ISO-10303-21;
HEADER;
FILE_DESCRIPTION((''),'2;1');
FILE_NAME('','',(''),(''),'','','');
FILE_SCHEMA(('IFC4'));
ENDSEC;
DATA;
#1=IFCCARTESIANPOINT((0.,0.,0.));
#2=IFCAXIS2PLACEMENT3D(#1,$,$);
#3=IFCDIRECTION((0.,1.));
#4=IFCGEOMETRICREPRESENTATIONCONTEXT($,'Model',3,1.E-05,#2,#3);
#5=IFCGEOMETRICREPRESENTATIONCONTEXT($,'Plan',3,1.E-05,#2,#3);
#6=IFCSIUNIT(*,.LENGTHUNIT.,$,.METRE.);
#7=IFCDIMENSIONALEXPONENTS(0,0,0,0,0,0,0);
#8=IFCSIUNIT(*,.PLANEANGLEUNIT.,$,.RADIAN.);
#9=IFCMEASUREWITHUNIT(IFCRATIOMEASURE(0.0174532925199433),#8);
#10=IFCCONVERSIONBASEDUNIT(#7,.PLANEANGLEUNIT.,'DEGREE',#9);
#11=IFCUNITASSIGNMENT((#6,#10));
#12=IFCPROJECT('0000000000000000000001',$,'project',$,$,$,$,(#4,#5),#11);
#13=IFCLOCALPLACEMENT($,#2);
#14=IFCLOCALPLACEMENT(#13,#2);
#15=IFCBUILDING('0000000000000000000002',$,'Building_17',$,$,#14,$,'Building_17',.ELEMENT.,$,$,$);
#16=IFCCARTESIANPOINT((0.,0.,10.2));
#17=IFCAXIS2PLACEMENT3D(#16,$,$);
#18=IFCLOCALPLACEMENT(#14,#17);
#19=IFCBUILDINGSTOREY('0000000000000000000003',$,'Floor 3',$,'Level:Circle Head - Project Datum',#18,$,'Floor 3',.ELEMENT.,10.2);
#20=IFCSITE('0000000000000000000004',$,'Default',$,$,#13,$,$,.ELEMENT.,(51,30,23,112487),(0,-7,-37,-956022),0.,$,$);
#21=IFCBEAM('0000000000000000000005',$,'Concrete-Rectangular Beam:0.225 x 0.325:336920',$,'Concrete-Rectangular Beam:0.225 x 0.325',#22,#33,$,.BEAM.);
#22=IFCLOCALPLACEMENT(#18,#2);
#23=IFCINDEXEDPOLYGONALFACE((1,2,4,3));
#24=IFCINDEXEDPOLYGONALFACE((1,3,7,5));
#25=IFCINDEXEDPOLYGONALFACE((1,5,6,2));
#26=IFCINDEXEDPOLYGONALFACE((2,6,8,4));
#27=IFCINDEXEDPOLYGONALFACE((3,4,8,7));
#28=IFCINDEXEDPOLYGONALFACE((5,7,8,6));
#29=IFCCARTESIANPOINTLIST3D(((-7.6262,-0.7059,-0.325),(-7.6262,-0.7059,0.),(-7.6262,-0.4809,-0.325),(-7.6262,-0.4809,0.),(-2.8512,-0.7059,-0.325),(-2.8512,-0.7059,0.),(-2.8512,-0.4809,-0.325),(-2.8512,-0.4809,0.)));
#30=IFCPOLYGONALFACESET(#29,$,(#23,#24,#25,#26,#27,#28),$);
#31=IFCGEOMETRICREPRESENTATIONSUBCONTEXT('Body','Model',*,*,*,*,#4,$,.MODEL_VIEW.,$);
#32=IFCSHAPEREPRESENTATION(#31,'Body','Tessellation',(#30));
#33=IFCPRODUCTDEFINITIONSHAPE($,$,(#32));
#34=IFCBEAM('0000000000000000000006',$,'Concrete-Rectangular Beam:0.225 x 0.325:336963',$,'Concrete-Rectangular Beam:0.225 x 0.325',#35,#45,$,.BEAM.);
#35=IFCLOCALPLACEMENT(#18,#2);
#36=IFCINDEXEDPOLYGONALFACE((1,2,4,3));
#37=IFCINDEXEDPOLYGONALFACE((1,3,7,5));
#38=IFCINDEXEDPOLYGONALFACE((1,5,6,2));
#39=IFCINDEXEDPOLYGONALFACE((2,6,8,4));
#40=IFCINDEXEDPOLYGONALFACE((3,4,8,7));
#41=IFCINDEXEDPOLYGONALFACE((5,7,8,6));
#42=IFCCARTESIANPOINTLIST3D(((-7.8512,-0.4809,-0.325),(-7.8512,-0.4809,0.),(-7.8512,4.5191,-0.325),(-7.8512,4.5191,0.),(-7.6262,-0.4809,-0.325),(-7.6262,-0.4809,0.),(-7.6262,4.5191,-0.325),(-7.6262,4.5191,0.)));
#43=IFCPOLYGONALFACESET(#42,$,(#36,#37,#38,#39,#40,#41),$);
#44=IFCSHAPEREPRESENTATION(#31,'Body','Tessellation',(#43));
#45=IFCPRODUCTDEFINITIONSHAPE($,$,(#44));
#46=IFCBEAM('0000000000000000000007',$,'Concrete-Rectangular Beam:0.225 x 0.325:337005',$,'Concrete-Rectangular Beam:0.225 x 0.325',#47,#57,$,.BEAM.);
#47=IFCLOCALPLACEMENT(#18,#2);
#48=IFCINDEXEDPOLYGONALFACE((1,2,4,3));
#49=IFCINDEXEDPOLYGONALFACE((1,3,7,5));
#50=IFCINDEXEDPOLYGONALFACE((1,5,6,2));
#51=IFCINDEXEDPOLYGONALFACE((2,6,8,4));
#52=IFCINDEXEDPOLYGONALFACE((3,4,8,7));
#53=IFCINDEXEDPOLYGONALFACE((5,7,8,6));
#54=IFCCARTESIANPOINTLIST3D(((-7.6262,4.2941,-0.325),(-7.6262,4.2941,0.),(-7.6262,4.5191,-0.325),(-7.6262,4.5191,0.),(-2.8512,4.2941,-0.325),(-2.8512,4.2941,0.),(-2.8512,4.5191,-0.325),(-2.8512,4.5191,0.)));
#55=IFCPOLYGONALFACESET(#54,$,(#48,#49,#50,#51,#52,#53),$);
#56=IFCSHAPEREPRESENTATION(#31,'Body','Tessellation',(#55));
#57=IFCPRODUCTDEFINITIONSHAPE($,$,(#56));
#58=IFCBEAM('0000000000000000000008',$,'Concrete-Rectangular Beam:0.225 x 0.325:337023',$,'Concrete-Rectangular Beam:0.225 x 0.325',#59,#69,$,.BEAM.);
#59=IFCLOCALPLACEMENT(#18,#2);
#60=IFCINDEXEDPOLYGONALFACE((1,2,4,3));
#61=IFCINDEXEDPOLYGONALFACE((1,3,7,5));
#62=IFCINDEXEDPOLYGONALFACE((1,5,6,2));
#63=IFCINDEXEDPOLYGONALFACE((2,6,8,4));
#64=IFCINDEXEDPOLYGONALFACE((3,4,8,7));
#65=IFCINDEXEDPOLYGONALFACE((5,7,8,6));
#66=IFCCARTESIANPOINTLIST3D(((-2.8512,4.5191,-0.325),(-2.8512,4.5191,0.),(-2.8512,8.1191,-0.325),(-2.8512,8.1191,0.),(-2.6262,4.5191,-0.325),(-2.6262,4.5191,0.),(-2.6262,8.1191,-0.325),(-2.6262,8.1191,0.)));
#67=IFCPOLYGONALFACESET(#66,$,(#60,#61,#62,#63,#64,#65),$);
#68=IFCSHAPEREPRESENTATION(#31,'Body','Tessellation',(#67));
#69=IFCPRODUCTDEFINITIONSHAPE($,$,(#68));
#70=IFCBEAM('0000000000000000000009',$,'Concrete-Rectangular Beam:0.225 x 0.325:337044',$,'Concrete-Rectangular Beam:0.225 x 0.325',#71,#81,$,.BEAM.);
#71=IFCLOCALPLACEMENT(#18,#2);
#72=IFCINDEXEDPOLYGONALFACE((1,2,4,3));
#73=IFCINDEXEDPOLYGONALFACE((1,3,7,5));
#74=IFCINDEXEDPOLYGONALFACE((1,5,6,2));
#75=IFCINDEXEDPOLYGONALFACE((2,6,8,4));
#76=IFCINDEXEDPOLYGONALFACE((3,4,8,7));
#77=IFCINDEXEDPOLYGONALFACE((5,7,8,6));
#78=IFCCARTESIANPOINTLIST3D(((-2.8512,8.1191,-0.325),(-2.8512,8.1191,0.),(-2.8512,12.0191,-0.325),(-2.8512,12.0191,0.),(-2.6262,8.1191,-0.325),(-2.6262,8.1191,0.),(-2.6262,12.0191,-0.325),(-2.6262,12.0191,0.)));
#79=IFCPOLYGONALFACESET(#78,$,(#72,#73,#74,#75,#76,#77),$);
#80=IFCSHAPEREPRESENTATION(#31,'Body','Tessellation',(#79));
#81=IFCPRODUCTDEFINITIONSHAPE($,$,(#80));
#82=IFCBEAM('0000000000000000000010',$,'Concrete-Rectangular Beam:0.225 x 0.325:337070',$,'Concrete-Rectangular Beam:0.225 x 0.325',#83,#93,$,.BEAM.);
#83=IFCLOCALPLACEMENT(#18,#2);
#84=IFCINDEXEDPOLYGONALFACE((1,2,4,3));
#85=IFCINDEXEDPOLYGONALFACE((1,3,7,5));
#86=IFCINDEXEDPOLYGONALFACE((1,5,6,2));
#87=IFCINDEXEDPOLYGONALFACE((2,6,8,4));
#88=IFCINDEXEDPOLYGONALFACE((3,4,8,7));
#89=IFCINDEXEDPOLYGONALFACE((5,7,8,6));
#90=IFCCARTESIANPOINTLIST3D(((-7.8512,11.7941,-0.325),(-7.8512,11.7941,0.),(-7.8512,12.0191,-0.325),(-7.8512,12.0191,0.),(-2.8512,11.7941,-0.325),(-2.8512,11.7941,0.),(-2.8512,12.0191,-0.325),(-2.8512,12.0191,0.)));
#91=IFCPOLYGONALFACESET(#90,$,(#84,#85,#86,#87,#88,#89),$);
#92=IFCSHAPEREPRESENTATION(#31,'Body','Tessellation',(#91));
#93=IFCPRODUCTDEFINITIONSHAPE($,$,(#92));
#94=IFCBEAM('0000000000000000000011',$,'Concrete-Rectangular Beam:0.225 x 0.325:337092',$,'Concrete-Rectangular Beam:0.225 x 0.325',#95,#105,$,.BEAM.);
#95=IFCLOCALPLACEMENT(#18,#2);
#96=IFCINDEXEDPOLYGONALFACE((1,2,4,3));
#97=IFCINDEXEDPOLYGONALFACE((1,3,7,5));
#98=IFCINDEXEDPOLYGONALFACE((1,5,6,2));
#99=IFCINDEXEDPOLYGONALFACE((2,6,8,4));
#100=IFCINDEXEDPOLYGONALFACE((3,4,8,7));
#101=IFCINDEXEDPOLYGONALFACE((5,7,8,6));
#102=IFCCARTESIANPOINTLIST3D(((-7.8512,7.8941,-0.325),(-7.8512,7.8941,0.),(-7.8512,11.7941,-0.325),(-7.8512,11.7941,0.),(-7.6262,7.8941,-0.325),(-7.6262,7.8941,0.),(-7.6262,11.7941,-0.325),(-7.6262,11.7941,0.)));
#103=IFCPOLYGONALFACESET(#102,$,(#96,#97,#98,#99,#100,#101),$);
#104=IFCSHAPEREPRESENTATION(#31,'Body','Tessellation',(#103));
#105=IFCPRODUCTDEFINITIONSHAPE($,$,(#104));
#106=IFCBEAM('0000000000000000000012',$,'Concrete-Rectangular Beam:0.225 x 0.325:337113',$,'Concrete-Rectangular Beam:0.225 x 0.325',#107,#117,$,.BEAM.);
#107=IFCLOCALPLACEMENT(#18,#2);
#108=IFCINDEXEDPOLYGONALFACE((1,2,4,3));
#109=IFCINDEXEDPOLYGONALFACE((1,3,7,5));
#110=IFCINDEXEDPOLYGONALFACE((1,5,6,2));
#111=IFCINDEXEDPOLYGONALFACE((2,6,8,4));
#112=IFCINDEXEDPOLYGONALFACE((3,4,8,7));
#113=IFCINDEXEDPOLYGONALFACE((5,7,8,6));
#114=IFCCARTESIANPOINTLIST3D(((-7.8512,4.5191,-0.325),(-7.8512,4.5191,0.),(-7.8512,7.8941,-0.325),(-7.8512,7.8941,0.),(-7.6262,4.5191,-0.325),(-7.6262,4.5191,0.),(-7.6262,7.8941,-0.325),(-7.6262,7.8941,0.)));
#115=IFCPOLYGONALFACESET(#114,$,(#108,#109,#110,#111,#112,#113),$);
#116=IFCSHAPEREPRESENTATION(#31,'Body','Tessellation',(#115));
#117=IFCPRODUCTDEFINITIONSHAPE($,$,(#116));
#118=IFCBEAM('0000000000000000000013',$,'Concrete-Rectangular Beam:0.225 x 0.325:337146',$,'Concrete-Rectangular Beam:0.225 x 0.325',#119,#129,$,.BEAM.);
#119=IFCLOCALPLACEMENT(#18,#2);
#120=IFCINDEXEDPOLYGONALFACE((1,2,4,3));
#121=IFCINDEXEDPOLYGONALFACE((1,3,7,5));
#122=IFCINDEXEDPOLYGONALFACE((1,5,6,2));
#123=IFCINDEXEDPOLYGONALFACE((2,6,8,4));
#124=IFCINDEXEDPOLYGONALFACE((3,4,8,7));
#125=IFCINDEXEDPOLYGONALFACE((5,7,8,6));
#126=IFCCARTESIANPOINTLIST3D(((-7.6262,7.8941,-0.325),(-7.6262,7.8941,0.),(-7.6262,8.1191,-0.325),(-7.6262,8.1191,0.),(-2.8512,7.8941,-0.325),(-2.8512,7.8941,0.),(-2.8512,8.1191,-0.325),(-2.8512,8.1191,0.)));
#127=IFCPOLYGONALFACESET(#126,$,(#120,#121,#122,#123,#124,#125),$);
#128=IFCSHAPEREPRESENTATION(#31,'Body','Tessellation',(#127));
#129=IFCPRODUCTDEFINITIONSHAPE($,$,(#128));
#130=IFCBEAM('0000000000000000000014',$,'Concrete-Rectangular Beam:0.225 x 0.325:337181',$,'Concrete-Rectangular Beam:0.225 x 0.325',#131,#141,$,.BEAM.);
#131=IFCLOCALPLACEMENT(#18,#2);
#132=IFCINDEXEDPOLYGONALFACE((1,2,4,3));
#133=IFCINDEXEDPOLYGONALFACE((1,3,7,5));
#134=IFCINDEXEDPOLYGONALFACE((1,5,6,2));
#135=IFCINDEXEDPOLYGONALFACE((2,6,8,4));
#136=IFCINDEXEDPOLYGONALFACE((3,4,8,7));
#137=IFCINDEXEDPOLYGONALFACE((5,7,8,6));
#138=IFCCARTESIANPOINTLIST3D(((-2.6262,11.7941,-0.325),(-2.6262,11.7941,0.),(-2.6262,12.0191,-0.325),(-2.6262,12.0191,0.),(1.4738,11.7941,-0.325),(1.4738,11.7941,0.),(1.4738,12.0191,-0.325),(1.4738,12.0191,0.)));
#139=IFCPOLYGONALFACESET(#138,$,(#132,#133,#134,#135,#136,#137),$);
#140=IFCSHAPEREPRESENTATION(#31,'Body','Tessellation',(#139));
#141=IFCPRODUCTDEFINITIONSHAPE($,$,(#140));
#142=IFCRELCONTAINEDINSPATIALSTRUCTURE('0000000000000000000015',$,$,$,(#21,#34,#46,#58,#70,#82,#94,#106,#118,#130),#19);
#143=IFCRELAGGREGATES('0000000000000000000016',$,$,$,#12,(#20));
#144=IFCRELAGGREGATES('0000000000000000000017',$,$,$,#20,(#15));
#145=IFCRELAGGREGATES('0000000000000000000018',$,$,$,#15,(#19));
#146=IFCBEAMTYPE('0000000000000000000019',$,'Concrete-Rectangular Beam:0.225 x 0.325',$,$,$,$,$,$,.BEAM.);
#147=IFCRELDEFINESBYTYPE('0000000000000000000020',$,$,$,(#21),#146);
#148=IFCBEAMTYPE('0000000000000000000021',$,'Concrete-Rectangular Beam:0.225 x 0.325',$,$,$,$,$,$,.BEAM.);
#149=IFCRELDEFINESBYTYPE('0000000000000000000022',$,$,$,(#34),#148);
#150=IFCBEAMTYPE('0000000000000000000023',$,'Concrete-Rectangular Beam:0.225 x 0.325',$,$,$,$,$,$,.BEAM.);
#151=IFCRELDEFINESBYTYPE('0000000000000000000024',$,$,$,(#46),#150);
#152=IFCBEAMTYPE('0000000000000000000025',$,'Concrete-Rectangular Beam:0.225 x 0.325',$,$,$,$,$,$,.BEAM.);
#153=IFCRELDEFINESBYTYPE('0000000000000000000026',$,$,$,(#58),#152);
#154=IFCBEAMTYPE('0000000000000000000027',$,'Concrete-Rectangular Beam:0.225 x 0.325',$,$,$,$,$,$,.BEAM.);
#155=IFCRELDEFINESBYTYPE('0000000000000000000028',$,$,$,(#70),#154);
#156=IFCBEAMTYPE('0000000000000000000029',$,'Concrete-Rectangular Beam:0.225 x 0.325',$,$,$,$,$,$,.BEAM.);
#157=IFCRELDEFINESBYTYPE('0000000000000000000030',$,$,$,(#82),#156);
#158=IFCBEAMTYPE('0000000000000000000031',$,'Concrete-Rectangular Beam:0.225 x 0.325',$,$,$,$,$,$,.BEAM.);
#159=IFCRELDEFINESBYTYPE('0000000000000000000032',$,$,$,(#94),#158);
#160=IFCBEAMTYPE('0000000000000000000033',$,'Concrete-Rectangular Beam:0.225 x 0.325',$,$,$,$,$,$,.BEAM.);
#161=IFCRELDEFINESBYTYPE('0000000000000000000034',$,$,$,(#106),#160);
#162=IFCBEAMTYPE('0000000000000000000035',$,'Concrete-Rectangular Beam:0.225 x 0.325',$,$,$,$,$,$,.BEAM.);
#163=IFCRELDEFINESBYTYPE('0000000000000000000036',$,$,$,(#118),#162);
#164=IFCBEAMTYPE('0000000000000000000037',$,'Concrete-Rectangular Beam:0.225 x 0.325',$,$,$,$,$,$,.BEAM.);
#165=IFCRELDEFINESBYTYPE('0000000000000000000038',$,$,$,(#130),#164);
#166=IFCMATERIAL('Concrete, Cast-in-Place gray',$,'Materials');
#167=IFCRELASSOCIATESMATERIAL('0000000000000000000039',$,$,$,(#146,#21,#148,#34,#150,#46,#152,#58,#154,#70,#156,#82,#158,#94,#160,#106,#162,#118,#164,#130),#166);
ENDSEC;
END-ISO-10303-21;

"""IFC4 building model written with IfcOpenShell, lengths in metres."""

from ifc_helpers import new_model, entity, si_unit, converted_unit, direction, frame, origin, place, context, subcontext, project, spatial, indexed_curve, outline, extrude, source, transform, mapped, material, type_object, type_shapes, element, save


model = new_model("IFC4")

# Units and contexts
model_context = context("Model", 3, precision=1e-05, world=origin(), true_north=direction((0.0, 1.0)))
plan_context = context("Plan", 3, precision=1e-05, world=origin(), true_north=direction((0.0, 1.0)))
body_context = subcontext(model_context, "Body", "Model", "MODEL_VIEW")
ifc_project = project(units=[si_unit("LENGTHUNIT", "METRE"), converted_unit("PLANEANGLEUNIT", "DEGREE", entity("IfcRatioMeasure", 0.0174532925199433), si_unit("PLANEANGLEUNIT", "RADIAN"), dimensions=[0, 0, 0, 0, 0, 0, 0])], contexts=[model_context, plan_context])

# Site, building, storey
site_placement = place(None, origin())
site = spatial("IfcSite", under=ifc_project, at=site_placement, Name="Default", CompositionType="ELEMENT", RefLatitude=(51, 30, 23, 112487), RefLongitude=(0, -7, -37, -956022), RefElevation=0.0)
building_placement = place(site_placement, origin())
building = spatial("IfcBuilding", under=site, at=building_placement, Name="Building_17", LongName="Building_17", CompositionType="ELEMENT")
storey_placement = place(building_placement, frame((0.0, 0.0, 10.2)))
storey = spatial("IfcBuildingStorey", under=building, at=storey_placement, Name="Floor 3", ObjectType="Level:Circle Head - Project Datum", LongName="Floor 3", CompositionType="ELEMENT", Elevation=10.2)

# Beams
ifc_material = material(Name="Concrete, Cast-in-Place gray", Category="Materials")
beam_type_1 = type_object("IfcBeamType", Name="Concrete-Rectangular Beam:0.225 x 0.325", PredefinedType="BEAM", material=ifc_material)
shared_shape_1 = source(origin(), body_context, "Body", "SweptSolid", [
    extrude(outline(indexed_curve([(-0.1625, -0.1125), (0.1625, -0.1125), (0.1625, 0.1125), (-0.1625, 0.1125), (-0.1625, -0.1125)], self_intersect=False)), frame((-7.6262, -0.5934, 10.0375), z_axis=(1.0, 0.0, 0.0), x_axis=(0.0, 0.0, -1.0)), (0.0, 0.0, 1.0), 4.775),
])
type_shapes(beam_type_1, [shared_shape_1])
beam_1_placement = place(storey_placement, frame((0.0, 0.0, -10.2)))
element("IfcBeam", 1, at=beam_1_placement, inside=storey, type_object=beam_type_1, material=ifc_material, Name="Concrete-Rectangular Beam:0.225 x 0.325:336920", ObjectType="Concrete-Rectangular Beam:0.225 x 0.325", PredefinedType="BEAM", context=body_context, shape_type="MappedRepresentation", body=[
    mapped(shared_shape_1, transform((0.0, 0.0, 0.0), scale=1.0)),
])
beam_type_2 = type_object("IfcBeamType", Name="Concrete-Rectangular Beam:0.225 x 0.325", PredefinedType="BEAM", material=ifc_material)
shared_shape_2 = source(origin(), body_context, "Body", "SweptSolid", [
    extrude(outline(indexed_curve([(-0.1125, -0.1625), (0.1125, -0.1625), (0.1125, 0.1625), (-0.1125, 0.1625), (-0.1125, -0.1625)], self_intersect=False)), frame((-7.7387, 4.5191, 10.0375), z_axis=(0.0, -1.0, 0.0), x_axis=(-1.0, 0.0, 0.0)), (0.0, 0.0, 1.0), 5.0),
])
type_shapes(beam_type_2, [shared_shape_2])
beam_2_placement = place(storey_placement, frame((0.0, 0.0, -10.2)))
element("IfcBeam", 2, at=beam_2_placement, inside=storey, type_object=beam_type_2, material=ifc_material, Name="Concrete-Rectangular Beam:0.225 x 0.325:336963", ObjectType="Concrete-Rectangular Beam:0.225 x 0.325", PredefinedType="BEAM", context=body_context, shape_type="MappedRepresentation", body=[
    mapped(shared_shape_2, transform((0.0, 0.0, 0.0), scale=1.0)),
])
beam_type_3 = type_object("IfcBeamType", Name="Concrete-Rectangular Beam:0.225 x 0.325", PredefinedType="BEAM", material=ifc_material)
shared_shape_3 = source(origin(), body_context, "Body", "SweptSolid", [
    extrude(outline(indexed_curve([(-0.1625, -0.1125), (0.1625, -0.1125), (0.1625, 0.1125), (-0.1625, 0.1125), (-0.1625, -0.1125)], self_intersect=False)), frame((-7.6262, 4.4066, 10.0375), z_axis=(1.0, 0.0, 0.0), x_axis=(0.0, 0.0, -1.0)), (0.0, 0.0, 1.0), 4.775),
])
type_shapes(beam_type_3, [shared_shape_3])
beam_3_placement = place(storey_placement, frame((0.0, 0.0, -10.2)))
element("IfcBeam", 3, at=beam_3_placement, inside=storey, type_object=beam_type_3, material=ifc_material, Name="Concrete-Rectangular Beam:0.225 x 0.325:337005", ObjectType="Concrete-Rectangular Beam:0.225 x 0.325", PredefinedType="BEAM", context=body_context, shape_type="MappedRepresentation", body=[
    mapped(shared_shape_3, transform((0.0, 0.0, 0.0), scale=1.0)),
])
beam_type_4 = type_object("IfcBeamType", Name="Concrete-Rectangular Beam:0.225 x 0.325", PredefinedType="BEAM", material=ifc_material)
shared_shape_4 = source(origin(), body_context, "Body", "SweptSolid", [
    extrude(outline(indexed_curve([(-0.1125, -0.1625), (0.1125, -0.1625), (0.1125, 0.1625), (-0.1125, 0.1625), (-0.1125, -0.1625)], self_intersect=False)), frame((-2.7387, 4.5191, 10.0375), z_axis=(0.0, 1.0, 0.0), x_axis=(-1.0, 0.0, 0.0)), (0.0, 0.0, 1.0), 3.6),
])
type_shapes(beam_type_4, [shared_shape_4])
beam_4_placement = place(storey_placement, frame((0.0, 0.0, -10.2)))
element("IfcBeam", 4, at=beam_4_placement, inside=storey, type_object=beam_type_4, material=ifc_material, Name="Concrete-Rectangular Beam:0.225 x 0.325:337023", ObjectType="Concrete-Rectangular Beam:0.225 x 0.325", PredefinedType="BEAM", context=body_context, shape_type="MappedRepresentation", body=[
    mapped(shared_shape_4, transform((0.0, 0.0, 0.0), scale=1.0)),
])
beam_type_5 = type_object("IfcBeamType", Name="Concrete-Rectangular Beam:0.225 x 0.325", PredefinedType="BEAM", material=ifc_material)
shared_shape_5 = source(origin(), body_context, "Body", "SweptSolid", [
    extrude(outline(indexed_curve([(-0.1125, -0.1625), (0.1125, -0.1625), (0.1125, 0.1625), (-0.1125, 0.1625), (-0.1125, -0.1625)], self_intersect=False)), frame((-2.7387, 8.1191, 10.0375), z_axis=(0.0, 1.0, 0.0), x_axis=(-1.0, 0.0, 0.0)), (0.0, 0.0, 1.0), 3.9),
])
type_shapes(beam_type_5, [shared_shape_5])
beam_5_placement = place(storey_placement, frame((0.0, 0.0, -10.2)))
element("IfcBeam", 5, at=beam_5_placement, inside=storey, type_object=beam_type_5, material=ifc_material, Name="Concrete-Rectangular Beam:0.225 x 0.325:337044", ObjectType="Concrete-Rectangular Beam:0.225 x 0.325", PredefinedType="BEAM", context=body_context, shape_type="MappedRepresentation", body=[
    mapped(shared_shape_5, transform((0.0, 0.0, 0.0), scale=1.0)),
])
beam_type_6 = type_object("IfcBeamType", Name="Concrete-Rectangular Beam:0.225 x 0.325", PredefinedType="BEAM", material=ifc_material)
shared_shape_6 = source(origin(), body_context, "Body", "SweptSolid", [
    extrude(outline(indexed_curve([(-0.1625, -0.1125), (0.1625, -0.1125), (0.1625, 0.1125), (-0.1625, 0.1125), (-0.1625, -0.1125)], self_intersect=False)), frame((-2.8512, 11.9066, 10.0375), z_axis=(-1.0, 0.0, 0.0), x_axis=(0.0, 0.0, -1.0)), (0.0, 0.0, 1.0), 5.0),
])
type_shapes(beam_type_6, [shared_shape_6])
beam_6_placement = place(storey_placement, frame((0.0, 0.0, -10.2)))
element("IfcBeam", 6, at=beam_6_placement, inside=storey, type_object=beam_type_6, material=ifc_material, Name="Concrete-Rectangular Beam:0.225 x 0.325:337070", ObjectType="Concrete-Rectangular Beam:0.225 x 0.325", PredefinedType="BEAM", context=body_context, shape_type="MappedRepresentation", body=[
    mapped(shared_shape_6, transform((0.0, 0.0, 0.0), scale=1.0)),
])
beam_type_7 = type_object("IfcBeamType", Name="Concrete-Rectangular Beam:0.225 x 0.325", PredefinedType="BEAM", material=ifc_material)
shared_shape_7 = source(origin(), body_context, "Body", "SweptSolid", [
    extrude(outline(indexed_curve([(-0.1125, -0.1625), (0.1125, -0.1625), (0.1125, 0.1625), (-0.1125, 0.1625), (-0.1125, -0.1625)], self_intersect=False)), frame((-7.7387, 11.7941, 10.0375), z_axis=(0.0, -1.0, 0.0), x_axis=(-1.0, 0.0, 0.0)), (0.0, 0.0, 1.0), 3.9),
])
type_shapes(beam_type_7, [shared_shape_7])
beam_7_placement = place(storey_placement, frame((0.0, 0.0, -10.2)))
element("IfcBeam", 7, at=beam_7_placement, inside=storey, type_object=beam_type_7, material=ifc_material, Name="Concrete-Rectangular Beam:0.225 x 0.325:337092", ObjectType="Concrete-Rectangular Beam:0.225 x 0.325", PredefinedType="BEAM", context=body_context, shape_type="MappedRepresentation", body=[
    mapped(shared_shape_7, transform((0.0, 0.0, 0.0), scale=1.0)),
])
beam_type_8 = type_object("IfcBeamType", Name="Concrete-Rectangular Beam:0.225 x 0.325", PredefinedType="BEAM", material=ifc_material)
shared_shape_8 = source(origin(), body_context, "Body", "SweptSolid", [
    extrude(outline(indexed_curve([(-0.1125, -0.1625), (0.1125, -0.1625), (0.1125, 0.1625), (-0.1125, 0.1625), (-0.1125, -0.1625)], self_intersect=False)), frame((-7.7387, 7.8941, 10.0375), z_axis=(0.0, -1.0, 0.0), x_axis=(-1.0, 0.0, 0.0)), (0.0, 0.0, 1.0), 3.375),
])
type_shapes(beam_type_8, [shared_shape_8])
beam_8_placement = place(storey_placement, frame((0.0, 0.0, -10.2)))
element("IfcBeam", 8, at=beam_8_placement, inside=storey, type_object=beam_type_8, material=ifc_material, Name="Concrete-Rectangular Beam:0.225 x 0.325:337113", ObjectType="Concrete-Rectangular Beam:0.225 x 0.325", PredefinedType="BEAM", context=body_context, shape_type="MappedRepresentation", body=[
    mapped(shared_shape_8, transform((0.0, 0.0, 0.0), scale=1.0)),
])
beam_type_9 = type_object("IfcBeamType", Name="Concrete-Rectangular Beam:0.225 x 0.325", PredefinedType="BEAM", material=ifc_material)
shared_shape_9 = source(origin(), body_context, "Body", "SweptSolid", [
    extrude(outline(indexed_curve([(-0.1625, -0.1125), (0.1625, -0.1125), (0.1625, 0.1125), (-0.1625, 0.1125), (-0.1625, -0.1125)], self_intersect=False)), frame((-7.6262, 8.0066, 10.0375), z_axis=(1.0, 0.0, 0.0), x_axis=(0.0, 0.0, -1.0)), (0.0, 0.0, 1.0), 4.775),
])
type_shapes(beam_type_9, [shared_shape_9])
beam_9_placement = place(storey_placement, frame((0.0, 0.0, -10.2)))
element("IfcBeam", 9, at=beam_9_placement, inside=storey, type_object=beam_type_9, material=ifc_material, Name="Concrete-Rectangular Beam:0.225 x 0.325:337146", ObjectType="Concrete-Rectangular Beam:0.225 x 0.325", PredefinedType="BEAM", context=body_context, shape_type="MappedRepresentation", body=[
    mapped(shared_shape_9, transform((0.0, 0.0, 0.0), scale=1.0)),
])
beam_type_10 = type_object("IfcBeamType", Name="Concrete-Rectangular Beam:0.225 x 0.325", PredefinedType="BEAM", material=ifc_material)
shared_shape_10 = source(origin(), body_context, "Body", "SweptSolid", [
    extrude(outline(indexed_curve([(-0.1625, -0.1125), (0.1625, -0.1125), (0.1625, 0.1125), (-0.1625, 0.1125), (-0.1625, -0.1125)], self_intersect=False)), frame((-2.6262, 11.9066, 10.0375), z_axis=(1.0, 0.0, 0.0), x_axis=(0.0, 0.0, -1.0)), (0.0, 0.0, 1.0), 4.1),
])
type_shapes(beam_type_10, [shared_shape_10])
beam_10_placement = place(storey_placement, frame((0.0, 0.0, -10.2)))
element("IfcBeam", 10, at=beam_10_placement, inside=storey, type_object=beam_type_10, material=ifc_material, Name="Concrete-Rectangular Beam:0.225 x 0.325:337181", ObjectType="Concrete-Rectangular Beam:0.225 x 0.325", PredefinedType="BEAM", context=body_context, shape_type="MappedRepresentation", body=[
    mapped(shared_shape_10, transform((0.0, 0.0, 0.0), scale=1.0)),
])

save(model, "model.ifc")
